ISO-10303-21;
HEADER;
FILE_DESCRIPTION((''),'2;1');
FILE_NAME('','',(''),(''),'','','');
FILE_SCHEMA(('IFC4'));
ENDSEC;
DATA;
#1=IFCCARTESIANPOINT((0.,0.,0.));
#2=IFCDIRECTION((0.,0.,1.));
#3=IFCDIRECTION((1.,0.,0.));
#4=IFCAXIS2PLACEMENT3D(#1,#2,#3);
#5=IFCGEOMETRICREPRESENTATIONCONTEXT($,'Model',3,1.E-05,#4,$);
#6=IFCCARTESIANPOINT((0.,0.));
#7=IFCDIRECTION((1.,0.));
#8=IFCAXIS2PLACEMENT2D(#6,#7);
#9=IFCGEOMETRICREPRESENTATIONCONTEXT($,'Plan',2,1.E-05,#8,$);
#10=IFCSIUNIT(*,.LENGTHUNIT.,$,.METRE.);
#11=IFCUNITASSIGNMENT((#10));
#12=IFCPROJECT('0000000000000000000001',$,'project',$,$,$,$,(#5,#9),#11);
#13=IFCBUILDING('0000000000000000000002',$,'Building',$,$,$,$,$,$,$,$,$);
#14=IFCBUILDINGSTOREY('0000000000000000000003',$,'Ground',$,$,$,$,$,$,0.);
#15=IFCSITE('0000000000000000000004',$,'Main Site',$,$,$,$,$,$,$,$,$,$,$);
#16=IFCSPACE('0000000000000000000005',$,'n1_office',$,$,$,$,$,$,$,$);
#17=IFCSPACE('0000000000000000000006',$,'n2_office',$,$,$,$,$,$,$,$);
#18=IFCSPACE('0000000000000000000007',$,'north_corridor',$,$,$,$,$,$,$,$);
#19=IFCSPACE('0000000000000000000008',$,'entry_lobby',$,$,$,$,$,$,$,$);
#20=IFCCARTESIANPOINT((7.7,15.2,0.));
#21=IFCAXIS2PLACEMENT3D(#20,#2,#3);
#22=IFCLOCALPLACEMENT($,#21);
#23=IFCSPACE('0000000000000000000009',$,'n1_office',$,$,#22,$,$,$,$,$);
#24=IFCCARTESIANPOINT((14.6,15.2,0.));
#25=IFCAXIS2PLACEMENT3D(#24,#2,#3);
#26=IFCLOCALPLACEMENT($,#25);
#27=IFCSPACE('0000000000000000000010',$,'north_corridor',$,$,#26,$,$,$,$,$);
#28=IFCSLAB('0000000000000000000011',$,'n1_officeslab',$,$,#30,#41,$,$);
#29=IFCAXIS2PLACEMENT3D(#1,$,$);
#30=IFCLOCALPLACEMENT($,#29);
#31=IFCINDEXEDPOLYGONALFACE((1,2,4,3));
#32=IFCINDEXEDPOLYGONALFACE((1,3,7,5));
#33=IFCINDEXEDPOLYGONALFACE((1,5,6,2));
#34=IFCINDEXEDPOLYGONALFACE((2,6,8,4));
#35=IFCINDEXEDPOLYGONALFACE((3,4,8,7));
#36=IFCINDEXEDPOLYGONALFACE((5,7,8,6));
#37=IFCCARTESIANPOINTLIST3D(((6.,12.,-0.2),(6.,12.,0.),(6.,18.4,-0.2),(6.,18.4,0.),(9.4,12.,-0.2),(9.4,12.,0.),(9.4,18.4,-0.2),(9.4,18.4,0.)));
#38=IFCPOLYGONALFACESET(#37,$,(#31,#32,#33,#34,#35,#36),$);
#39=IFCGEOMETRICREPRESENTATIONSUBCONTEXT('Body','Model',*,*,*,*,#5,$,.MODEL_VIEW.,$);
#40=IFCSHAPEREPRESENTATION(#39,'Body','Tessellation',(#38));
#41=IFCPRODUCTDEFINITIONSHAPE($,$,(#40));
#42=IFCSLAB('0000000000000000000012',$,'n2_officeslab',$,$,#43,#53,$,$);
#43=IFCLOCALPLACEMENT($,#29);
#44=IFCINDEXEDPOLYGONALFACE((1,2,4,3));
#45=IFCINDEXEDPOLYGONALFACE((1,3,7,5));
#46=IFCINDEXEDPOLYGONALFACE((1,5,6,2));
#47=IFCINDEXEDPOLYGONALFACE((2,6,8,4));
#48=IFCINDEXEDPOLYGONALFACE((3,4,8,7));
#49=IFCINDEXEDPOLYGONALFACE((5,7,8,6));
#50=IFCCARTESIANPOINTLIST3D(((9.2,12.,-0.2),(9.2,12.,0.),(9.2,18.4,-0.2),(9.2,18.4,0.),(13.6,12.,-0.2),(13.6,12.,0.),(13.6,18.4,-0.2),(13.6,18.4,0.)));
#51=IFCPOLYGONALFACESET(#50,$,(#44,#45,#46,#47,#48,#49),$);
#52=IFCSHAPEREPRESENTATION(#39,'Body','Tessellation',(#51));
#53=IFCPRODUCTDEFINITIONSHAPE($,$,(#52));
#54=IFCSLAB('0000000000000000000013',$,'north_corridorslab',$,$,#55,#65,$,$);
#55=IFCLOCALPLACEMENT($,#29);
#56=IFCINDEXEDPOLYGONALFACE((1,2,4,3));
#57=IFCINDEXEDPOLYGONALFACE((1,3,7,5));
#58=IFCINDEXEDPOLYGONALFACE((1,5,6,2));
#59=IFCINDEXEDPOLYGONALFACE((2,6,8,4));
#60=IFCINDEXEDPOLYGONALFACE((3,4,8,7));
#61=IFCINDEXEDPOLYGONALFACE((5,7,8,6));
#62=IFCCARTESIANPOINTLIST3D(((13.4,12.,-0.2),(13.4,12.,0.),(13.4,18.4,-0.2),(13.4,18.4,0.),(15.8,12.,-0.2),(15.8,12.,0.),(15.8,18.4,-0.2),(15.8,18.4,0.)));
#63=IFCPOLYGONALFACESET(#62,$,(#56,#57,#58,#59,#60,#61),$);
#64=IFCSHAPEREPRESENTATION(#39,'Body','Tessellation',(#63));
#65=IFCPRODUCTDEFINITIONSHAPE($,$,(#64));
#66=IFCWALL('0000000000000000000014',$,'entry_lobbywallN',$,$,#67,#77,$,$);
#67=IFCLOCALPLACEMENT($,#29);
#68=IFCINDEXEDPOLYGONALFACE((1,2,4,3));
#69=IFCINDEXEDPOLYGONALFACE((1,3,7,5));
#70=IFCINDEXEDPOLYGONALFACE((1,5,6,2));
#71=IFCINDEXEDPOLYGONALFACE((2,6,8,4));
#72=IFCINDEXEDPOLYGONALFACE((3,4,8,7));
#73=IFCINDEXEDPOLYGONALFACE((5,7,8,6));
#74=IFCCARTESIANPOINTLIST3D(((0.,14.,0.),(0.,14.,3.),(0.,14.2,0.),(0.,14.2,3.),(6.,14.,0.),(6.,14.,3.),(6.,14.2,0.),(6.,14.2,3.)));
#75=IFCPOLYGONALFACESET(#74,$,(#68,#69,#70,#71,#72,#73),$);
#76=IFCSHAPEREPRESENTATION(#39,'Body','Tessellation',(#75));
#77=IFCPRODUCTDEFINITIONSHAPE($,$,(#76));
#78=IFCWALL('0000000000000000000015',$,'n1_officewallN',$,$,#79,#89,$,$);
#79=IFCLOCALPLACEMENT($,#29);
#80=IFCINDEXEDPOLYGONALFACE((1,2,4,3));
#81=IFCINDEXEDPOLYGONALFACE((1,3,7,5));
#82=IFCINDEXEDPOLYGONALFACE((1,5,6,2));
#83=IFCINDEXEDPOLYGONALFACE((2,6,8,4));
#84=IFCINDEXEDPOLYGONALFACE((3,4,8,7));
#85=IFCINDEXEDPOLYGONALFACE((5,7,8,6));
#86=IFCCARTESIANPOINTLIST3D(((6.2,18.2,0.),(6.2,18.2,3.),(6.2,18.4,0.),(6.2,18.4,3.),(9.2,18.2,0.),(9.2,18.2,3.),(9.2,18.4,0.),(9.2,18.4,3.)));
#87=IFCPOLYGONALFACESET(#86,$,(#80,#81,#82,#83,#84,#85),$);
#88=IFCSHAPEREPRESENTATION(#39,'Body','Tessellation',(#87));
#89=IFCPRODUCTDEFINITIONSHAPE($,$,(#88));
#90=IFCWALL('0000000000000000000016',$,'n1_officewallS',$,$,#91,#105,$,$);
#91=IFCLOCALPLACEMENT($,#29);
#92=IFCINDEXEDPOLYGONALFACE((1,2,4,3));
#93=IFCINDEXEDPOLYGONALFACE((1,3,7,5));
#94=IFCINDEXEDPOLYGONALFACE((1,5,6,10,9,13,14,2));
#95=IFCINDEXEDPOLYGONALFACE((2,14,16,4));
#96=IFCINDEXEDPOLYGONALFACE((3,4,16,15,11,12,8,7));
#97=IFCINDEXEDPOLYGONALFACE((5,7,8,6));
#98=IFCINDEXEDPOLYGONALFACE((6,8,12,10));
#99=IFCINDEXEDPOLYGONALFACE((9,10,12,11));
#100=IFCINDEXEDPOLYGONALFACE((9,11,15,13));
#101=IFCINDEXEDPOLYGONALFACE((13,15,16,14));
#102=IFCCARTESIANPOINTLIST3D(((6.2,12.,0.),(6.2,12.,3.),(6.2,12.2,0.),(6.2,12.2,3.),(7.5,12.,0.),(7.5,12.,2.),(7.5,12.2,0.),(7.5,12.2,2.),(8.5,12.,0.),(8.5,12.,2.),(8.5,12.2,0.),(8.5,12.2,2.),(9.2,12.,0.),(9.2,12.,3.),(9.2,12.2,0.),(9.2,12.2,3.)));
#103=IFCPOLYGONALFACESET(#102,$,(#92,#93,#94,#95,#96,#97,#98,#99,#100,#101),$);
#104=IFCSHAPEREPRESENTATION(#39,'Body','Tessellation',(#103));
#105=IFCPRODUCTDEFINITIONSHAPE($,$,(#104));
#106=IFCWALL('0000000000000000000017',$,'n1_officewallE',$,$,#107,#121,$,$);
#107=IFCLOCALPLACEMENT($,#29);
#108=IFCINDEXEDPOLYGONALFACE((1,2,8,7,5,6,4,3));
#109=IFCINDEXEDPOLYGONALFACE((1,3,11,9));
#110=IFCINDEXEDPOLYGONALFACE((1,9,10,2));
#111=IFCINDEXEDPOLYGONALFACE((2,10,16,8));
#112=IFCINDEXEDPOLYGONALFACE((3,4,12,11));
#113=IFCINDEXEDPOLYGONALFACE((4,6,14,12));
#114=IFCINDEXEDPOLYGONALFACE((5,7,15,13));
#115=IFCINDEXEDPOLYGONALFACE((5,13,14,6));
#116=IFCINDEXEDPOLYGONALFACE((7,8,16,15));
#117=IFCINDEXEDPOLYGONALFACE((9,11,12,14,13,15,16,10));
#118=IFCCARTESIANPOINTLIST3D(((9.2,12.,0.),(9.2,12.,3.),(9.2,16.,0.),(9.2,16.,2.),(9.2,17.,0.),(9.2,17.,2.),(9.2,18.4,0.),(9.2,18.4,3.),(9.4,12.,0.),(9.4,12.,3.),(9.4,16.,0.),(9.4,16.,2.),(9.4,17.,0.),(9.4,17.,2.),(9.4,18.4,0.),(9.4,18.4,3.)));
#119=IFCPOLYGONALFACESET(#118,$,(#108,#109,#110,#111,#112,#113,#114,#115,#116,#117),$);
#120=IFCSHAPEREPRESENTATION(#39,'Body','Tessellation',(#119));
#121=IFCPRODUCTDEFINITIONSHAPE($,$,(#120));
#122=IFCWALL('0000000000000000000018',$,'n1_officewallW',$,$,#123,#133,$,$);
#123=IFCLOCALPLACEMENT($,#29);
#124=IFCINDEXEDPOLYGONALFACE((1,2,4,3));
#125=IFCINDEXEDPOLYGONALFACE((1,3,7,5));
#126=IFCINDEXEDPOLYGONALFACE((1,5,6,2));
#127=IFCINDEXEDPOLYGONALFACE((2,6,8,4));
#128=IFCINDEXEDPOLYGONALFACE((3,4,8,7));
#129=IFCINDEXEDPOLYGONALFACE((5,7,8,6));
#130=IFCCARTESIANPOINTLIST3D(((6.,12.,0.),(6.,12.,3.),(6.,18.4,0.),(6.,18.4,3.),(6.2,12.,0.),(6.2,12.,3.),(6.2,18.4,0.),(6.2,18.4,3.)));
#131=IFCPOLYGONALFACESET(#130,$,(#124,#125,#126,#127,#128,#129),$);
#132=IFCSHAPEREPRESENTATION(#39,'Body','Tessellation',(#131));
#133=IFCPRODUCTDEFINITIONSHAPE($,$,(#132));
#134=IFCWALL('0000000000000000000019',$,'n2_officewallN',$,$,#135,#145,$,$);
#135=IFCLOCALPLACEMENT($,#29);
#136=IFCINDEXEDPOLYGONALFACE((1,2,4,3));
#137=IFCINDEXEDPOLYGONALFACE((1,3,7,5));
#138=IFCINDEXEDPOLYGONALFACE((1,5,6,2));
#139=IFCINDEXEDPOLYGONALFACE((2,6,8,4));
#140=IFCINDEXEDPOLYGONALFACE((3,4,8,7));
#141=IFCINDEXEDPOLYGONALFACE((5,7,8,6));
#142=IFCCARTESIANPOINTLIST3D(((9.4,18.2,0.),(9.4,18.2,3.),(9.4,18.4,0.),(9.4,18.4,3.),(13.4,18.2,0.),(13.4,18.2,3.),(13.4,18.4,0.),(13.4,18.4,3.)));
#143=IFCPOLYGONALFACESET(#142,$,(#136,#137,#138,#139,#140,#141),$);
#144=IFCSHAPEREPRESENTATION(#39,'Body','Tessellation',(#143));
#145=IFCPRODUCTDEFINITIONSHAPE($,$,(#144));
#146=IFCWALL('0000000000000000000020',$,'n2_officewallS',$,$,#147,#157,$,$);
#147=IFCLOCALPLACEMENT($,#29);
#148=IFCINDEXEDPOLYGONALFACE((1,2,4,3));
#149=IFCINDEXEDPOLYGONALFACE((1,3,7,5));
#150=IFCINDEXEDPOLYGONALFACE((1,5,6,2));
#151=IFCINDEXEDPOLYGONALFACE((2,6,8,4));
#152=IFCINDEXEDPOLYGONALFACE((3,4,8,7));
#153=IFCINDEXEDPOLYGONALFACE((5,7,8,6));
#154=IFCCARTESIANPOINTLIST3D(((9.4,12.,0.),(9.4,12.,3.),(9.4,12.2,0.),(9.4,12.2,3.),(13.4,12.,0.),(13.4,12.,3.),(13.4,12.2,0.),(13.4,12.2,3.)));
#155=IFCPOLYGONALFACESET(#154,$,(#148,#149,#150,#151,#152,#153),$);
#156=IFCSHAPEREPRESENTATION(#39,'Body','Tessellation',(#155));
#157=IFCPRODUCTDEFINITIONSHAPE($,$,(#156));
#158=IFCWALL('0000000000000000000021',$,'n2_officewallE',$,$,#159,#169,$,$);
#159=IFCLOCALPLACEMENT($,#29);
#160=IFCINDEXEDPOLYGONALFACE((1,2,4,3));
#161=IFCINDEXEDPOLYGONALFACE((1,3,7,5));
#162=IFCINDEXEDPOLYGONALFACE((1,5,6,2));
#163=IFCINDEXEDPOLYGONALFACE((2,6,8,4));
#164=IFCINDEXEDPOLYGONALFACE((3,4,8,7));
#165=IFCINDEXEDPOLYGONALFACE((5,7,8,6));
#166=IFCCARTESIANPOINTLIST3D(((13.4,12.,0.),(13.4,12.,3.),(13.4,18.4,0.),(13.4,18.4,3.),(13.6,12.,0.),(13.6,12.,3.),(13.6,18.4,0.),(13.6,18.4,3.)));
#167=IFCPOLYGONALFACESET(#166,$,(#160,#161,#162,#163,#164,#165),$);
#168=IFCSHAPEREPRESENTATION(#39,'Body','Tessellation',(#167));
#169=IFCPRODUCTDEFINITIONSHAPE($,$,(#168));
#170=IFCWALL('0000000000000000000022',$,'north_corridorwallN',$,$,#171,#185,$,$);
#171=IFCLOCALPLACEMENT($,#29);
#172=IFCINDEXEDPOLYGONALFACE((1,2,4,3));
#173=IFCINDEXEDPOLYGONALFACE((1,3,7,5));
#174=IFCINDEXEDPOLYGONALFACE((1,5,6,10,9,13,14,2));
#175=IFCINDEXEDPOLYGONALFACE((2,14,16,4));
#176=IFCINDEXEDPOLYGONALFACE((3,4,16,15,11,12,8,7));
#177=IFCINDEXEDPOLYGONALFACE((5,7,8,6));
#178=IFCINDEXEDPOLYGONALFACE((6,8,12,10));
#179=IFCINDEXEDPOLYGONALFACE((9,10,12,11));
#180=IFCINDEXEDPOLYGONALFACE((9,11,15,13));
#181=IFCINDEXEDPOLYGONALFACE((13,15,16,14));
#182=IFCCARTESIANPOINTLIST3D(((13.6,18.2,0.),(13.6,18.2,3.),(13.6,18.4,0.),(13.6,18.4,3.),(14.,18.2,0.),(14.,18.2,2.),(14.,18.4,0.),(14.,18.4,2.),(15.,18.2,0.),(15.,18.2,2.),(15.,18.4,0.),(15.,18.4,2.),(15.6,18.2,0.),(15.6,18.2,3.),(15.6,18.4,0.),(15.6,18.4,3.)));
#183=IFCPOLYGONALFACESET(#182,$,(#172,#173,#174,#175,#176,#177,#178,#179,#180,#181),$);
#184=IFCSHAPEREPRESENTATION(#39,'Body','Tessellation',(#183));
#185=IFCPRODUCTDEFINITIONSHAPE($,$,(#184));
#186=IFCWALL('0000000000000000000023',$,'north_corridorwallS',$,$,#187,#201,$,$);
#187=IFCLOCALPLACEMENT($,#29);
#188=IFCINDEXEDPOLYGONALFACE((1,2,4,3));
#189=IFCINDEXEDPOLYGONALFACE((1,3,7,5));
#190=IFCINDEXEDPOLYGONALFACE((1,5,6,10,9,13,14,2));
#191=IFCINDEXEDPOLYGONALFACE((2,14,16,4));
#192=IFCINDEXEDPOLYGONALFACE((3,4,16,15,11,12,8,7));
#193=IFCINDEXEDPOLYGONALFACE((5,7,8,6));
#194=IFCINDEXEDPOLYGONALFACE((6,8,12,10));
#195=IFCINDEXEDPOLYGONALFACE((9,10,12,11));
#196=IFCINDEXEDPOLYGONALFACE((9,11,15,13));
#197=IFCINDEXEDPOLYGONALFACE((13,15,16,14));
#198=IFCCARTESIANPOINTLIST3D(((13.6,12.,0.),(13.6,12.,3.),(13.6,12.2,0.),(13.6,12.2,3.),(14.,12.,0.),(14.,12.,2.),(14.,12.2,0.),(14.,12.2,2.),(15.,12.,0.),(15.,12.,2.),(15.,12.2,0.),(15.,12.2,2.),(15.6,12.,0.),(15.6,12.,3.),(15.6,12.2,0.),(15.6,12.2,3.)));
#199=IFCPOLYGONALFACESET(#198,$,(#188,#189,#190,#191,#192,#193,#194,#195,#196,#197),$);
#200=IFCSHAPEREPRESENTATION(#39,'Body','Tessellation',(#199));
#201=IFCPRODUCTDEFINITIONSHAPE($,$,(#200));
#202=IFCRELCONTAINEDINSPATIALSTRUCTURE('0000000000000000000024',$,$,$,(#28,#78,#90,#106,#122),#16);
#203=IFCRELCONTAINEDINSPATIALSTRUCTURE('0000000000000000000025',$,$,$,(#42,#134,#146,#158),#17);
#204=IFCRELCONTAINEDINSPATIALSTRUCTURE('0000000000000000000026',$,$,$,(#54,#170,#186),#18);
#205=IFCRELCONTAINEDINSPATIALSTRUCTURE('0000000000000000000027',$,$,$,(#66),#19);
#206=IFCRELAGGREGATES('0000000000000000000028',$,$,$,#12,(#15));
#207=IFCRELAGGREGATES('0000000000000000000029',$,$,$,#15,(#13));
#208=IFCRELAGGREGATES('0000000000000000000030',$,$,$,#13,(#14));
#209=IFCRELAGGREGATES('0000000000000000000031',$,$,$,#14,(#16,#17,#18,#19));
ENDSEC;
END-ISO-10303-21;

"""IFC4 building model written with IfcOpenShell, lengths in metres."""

from ifc_helpers import new_model, si_unit, frame, origin_with_axes, origin_2d_with_axis, place, context, subcontext, project, spatial, indexed_curve, rectangle, outline, extrude, element, save


model = new_model("IFC4")

# Units and contexts
model_context = context("Model", 3, precision=1e-05, world=origin_with_axes())
plan_context = context("Plan", 2, precision=1e-05, world=origin_2d_with_axis())
body_context = subcontext(model_context, "Body", "Model", "MODEL_VIEW")
ifc_project = project(units=[si_unit("LENGTHUNIT", "METRE")], contexts=[model_context, plan_context])

# Site, building, storey, space
site = spatial("IfcSite", under=ifc_project, Name="Main Site")
building = spatial("IfcBuilding", under=site, Name="Building")
storey = spatial("IfcBuildingStorey", under=building, Name="Ground", Elevation=0.0)
space_1 = spatial("IfcSpace", under=storey, Name="n1_office")

# Slab
slab_1_placement = place(None, frame((7.7, 15.2, -0.2), z_axis=(0.0, 0.0, 1.0), x_axis=(1.0, 0.0, 0.0)))
element("IfcSlab", 1, at=slab_1_placement, inside=space_1, Name="n1_officeslab", context=body_context, shape_type="SweptSolid", body=[
    extrude(rectangle(XDim=3.4, YDim=6.4), origin_with_axes(), (0.0, 0.0, 1.0), 0.2),
])

# Shared definitions
space_2 = spatial("IfcSpace", under=storey, Name="n2_office")

# Slab
slab_2_placement = place(None, frame((11.4, 15.2, -0.2), z_axis=(0.0, 0.0, 1.0), x_axis=(1.0, 0.0, 0.0)))
element("IfcSlab", 2, at=slab_2_placement, inside=space_2, Name="n2_officeslab", context=body_context, shape_type="SweptSolid", body=[
    extrude(rectangle(XDim=4.4, YDim=6.4), origin_with_axes(), (0.0, 0.0, 1.0), 0.2),
])

# Shared definitions
space_3 = spatial("IfcSpace", under=storey, Name="north_corridor")

# Slab
slab_3_placement = place(None, frame((14.6, 15.2, -0.2), z_axis=(0.0, 0.0, 1.0), x_axis=(1.0, 0.0, 0.0)))
element("IfcSlab", 3, at=slab_3_placement, inside=space_3, Name="north_corridorslab", context=body_context, shape_type="SweptSolid", body=[
    extrude(rectangle(XDim=2.4, YDim=6.4), origin_with_axes(), (0.0, 0.0, 1.0), 0.2),
])

# Shared definitions
space_4 = spatial("IfcSpace", under=storey, Name="entry_lobby")

# Walls
wall_1_placement = place(None, frame((0.0, 14.0, 0.0), z_axis=(0.0, 0.0, 1.0), x_axis=(1.0, 0.0, 0.0)))
element("IfcWall", 4, at=wall_1_placement, inside=space_4, Name="entry_lobbywallN", context=body_context, shape_type="SweptSolid", body=[
    extrude(outline(indexed_curve([(0.0, 0.0), (0.0, 0.2), (6.0, 0.2), (6.0, 0.0), (0.0, 0.0)], self_intersect=False)), origin_with_axes(), (0.0, 0.0, 1.0), 3.0),
])
wall_2_placement = place(None, frame((6.2, 18.2, 0.0), z_axis=(0.0, 0.0, 1.0), x_axis=(1.0, 0.0, 0.0)))
element("IfcWall", 5, at=wall_2_placement, inside=space_1, Name="n1_officewallN", context=body_context, shape_type="SweptSolid", body=[
    extrude(outline(indexed_curve([(0.0, 0.0), (0.0, 0.2), (3.0, 0.2), (3.0, 0.0), (0.0, 0.0)], self_intersect=False)), origin_with_axes(), (0.0, 0.0, 1.0), 3.0),
])

# Wall
wall_3_placement = place(None, frame((6.2, 12.0, 0.0), z_axis=(0.0, 0.0, 1.0), x_axis=(1.0, 0.0, 0.0)))
wall_3 = element("IfcWall", 6, at=wall_3_placement, inside=space_1, Name="n1_officewallS", context=body_context, shape_type="SweptSolid", body=[
    extrude(outline(indexed_curve([(0.0, 0.0), (0.0, 0.2), (3.0, 0.2), (3.0, 0.0), (0.0, 0.0)], self_intersect=False)), origin_with_axes(), (0.0, 0.0, 1.0), 3.0),
])

# Shared definitions
space_5_placement = place(None, frame((7.7, 15.2, 0.0), z_axis=(0.0, 0.0, 1.0), x_axis=(1.0, 0.0, 0.0)))
space_5 = spatial("IfcSpace", at=space_5_placement, Name="n1_office")

# Opening
opening_1_placement = place(wall_3_placement, frame((1.3, 0.0, 0.0), z_axis=(0.0, 0.0, 1.0), x_axis=(1.0, 0.0, 0.0)))
element("IfcOpeningElement", 7, at=opening_1_placement, inside=space_5, cuts=wall_3, context=body_context, shape_type="SweptSolid", body=[
    extrude(outline(indexed_curve([(0.0, 0.0), (0.0, 0.4), (1.0, 0.4), (1.0, 0.0), (0.0, 0.0)], self_intersect=False)), origin_with_axes(), (0.0, 0.0, 1.0), 2.0),
])

# Wall, opening
wall_4_placement = place(None, frame((9.4, 12.0, 0.0), z_axis=(0.0, 0.0, 1.0), x_axis=(0.0, 1.0, 0.0)))
wall_4 = element("IfcWall", 8, at=wall_4_placement, inside=space_1, Name="n1_officewallE", context=body_context, shape_type="SweptSolid", body=[
    extrude(outline(indexed_curve([(0.0, 0.0), (0.0, 0.2), (6.4, 0.2), (6.4, 0.0), (0.0, 0.0)], self_intersect=False)), origin_with_axes(), (0.0, 0.0, 1.0), 3.0),
])
opening_2_placement = place(wall_4_placement, frame((4.0, 0.0, 0.0), z_axis=(0.0, 0.0, 1.0), x_axis=(1.0, 0.0, 0.0)))
element("IfcOpeningElement", 9, at=opening_2_placement, inside=space_5, cuts=wall_4, context=body_context, shape_type="SweptSolid", body=[
    extrude(outline(indexed_curve([(0.0, 0.0), (0.0, 0.4), (1.0, 0.4), (1.0, 0.0), (0.0, 0.0)], self_intersect=False)), origin_with_axes(), (0.0, 0.0, 1.0), 2.0),
])

# Walls
wall_5_placement = place(None, frame((6.2, 12.0, 0.0), z_axis=(0.0, 0.0, 1.0), x_axis=(0.0, 1.0, 0.0)))
element("IfcWall", 10, at=wall_5_placement, inside=space_1, Name="n1_officewallW", context=body_context, shape_type="SweptSolid", body=[
    extrude(outline(indexed_curve([(0.0, 0.0), (0.0, 0.2), (6.4, 0.2), (6.4, 0.0), (0.0, 0.0)], self_intersect=False)), origin_with_axes(), (0.0, 0.0, 1.0), 3.0),
])
for number, where, z_axis, x_axis, name in (
    (11, (9.4, 18.2, 0.0), (0.0, 0.0, 1.0), (1.0, 0.0, 0.0), "n2_officewallN"),
    (12, (9.4, 12.0, 0.0), (0.0, 0.0, 1.0), (1.0, 0.0, 0.0), "n2_officewallS"),
):
    element("IfcWall", number, at=place(None, frame(where, z_axis=z_axis, x_axis=x_axis)), inside=space_2, Name=name, context=body_context, shape_type="SweptSolid", body=[
        extrude(outline(indexed_curve([(0.0, 0.0), (0.0, 0.2), (4.0, 0.2), (4.0, 0.0), (0.0, 0.0)], self_intersect=False)), origin_with_axes(), (0.0, 0.0, 1.0), 3.0),
    ])
wall_6_placement = place(None, frame((13.6, 12.0, 0.0), z_axis=(0.0, 0.0, 1.0), x_axis=(0.0, 1.0, 0.0)))
element("IfcWall", 13, at=wall_6_placement, inside=space_2, Name="n2_officewallE", context=body_context, shape_type="SweptSolid", body=[
    extrude(outline(indexed_curve([(0.0, 0.0), (0.0, 0.2), (6.4, 0.2), (6.4, 0.0), (0.0, 0.0)], self_intersect=False)), origin_with_axes(), (0.0, 0.0, 1.0), 3.0),
])

# Wall
wall_7_placement = place(None, frame((13.6, 18.2, 0.0), z_axis=(0.0, 0.0, 1.0), x_axis=(1.0, 0.0, 0.0)))
wall_7 = element("IfcWall", 14, at=wall_7_placement, inside=space_3, Name="north_corridorwallN", context=body_context, shape_type="SweptSolid", body=[
    extrude(outline(indexed_curve([(0.0, 0.0), (0.0, 0.2), (2.0, 0.2), (2.0, 0.0), (0.0, 0.0)], self_intersect=False)), origin_with_axes(), (0.0, 0.0, 1.0), 3.0),
])

# Shared definitions
space_6_placement = place(None, frame((14.6, 15.2, 0.0), z_axis=(0.0, 0.0, 1.0), x_axis=(1.0, 0.0, 0.0)))
space_6 = spatial("IfcSpace", at=space_6_placement, Name="north_corridor")

# Opening
opening_3_placement = place(wall_7_placement, frame((0.4, 0.0, 0.0), z_axis=(0.0, 0.0, 1.0), x_axis=(1.0, 0.0, 0.0)))
element("IfcOpeningElement", 15, at=opening_3_placement, inside=space_6, cuts=wall_7, context=body_context, shape_type="SweptSolid", body=[
    extrude(outline(indexed_curve([(0.0, 0.0), (0.0, 0.4), (1.0, 0.4), (1.0, 0.0), (0.0, 0.0)], self_intersect=False)), origin_with_axes(), (0.0, 0.0, 1.0), 2.0),
])

# Wall, opening
wall_8_placement = place(None, frame((13.6, 12.0, 0.0), z_axis=(0.0, 0.0, 1.0), x_axis=(1.0, 0.0, 0.0)))
wall_8 = element("IfcWall", 16, at=wall_8_placement, inside=space_3, Name="north_corridorwallS", context=body_context, shape_type="SweptSolid", body=[
    extrude(outline(indexed_curve([(0.0, 0.0), (0.0, 0.2), (2.0, 0.2), (2.0, 0.0), (0.0, 0.0)], self_intersect=False)), origin_with_axes(), (0.0, 0.0, 1.0), 3.0),
])
opening_4_placement = place(wall_8_placement, frame((0.4, 0.0, 0.0), z_axis=(0.0, 0.0, 1.0), x_axis=(1.0, 0.0, 0.0)))
element("IfcOpeningElement", 17, at=opening_4_placement, inside=space_6, cuts=wall_8, context=body_context, shape_type="SweptSolid", body=[
    extrude(outline(indexed_curve([(0.0, 0.0), (0.0, 0.4), (1.0, 0.4), (1.0, 0.0), (0.0, 0.0)], self_intersect=False)), origin_with_axes(), (0.0, 0.0, 1.0), 2.0),
])

save(model, "model.ifc")
